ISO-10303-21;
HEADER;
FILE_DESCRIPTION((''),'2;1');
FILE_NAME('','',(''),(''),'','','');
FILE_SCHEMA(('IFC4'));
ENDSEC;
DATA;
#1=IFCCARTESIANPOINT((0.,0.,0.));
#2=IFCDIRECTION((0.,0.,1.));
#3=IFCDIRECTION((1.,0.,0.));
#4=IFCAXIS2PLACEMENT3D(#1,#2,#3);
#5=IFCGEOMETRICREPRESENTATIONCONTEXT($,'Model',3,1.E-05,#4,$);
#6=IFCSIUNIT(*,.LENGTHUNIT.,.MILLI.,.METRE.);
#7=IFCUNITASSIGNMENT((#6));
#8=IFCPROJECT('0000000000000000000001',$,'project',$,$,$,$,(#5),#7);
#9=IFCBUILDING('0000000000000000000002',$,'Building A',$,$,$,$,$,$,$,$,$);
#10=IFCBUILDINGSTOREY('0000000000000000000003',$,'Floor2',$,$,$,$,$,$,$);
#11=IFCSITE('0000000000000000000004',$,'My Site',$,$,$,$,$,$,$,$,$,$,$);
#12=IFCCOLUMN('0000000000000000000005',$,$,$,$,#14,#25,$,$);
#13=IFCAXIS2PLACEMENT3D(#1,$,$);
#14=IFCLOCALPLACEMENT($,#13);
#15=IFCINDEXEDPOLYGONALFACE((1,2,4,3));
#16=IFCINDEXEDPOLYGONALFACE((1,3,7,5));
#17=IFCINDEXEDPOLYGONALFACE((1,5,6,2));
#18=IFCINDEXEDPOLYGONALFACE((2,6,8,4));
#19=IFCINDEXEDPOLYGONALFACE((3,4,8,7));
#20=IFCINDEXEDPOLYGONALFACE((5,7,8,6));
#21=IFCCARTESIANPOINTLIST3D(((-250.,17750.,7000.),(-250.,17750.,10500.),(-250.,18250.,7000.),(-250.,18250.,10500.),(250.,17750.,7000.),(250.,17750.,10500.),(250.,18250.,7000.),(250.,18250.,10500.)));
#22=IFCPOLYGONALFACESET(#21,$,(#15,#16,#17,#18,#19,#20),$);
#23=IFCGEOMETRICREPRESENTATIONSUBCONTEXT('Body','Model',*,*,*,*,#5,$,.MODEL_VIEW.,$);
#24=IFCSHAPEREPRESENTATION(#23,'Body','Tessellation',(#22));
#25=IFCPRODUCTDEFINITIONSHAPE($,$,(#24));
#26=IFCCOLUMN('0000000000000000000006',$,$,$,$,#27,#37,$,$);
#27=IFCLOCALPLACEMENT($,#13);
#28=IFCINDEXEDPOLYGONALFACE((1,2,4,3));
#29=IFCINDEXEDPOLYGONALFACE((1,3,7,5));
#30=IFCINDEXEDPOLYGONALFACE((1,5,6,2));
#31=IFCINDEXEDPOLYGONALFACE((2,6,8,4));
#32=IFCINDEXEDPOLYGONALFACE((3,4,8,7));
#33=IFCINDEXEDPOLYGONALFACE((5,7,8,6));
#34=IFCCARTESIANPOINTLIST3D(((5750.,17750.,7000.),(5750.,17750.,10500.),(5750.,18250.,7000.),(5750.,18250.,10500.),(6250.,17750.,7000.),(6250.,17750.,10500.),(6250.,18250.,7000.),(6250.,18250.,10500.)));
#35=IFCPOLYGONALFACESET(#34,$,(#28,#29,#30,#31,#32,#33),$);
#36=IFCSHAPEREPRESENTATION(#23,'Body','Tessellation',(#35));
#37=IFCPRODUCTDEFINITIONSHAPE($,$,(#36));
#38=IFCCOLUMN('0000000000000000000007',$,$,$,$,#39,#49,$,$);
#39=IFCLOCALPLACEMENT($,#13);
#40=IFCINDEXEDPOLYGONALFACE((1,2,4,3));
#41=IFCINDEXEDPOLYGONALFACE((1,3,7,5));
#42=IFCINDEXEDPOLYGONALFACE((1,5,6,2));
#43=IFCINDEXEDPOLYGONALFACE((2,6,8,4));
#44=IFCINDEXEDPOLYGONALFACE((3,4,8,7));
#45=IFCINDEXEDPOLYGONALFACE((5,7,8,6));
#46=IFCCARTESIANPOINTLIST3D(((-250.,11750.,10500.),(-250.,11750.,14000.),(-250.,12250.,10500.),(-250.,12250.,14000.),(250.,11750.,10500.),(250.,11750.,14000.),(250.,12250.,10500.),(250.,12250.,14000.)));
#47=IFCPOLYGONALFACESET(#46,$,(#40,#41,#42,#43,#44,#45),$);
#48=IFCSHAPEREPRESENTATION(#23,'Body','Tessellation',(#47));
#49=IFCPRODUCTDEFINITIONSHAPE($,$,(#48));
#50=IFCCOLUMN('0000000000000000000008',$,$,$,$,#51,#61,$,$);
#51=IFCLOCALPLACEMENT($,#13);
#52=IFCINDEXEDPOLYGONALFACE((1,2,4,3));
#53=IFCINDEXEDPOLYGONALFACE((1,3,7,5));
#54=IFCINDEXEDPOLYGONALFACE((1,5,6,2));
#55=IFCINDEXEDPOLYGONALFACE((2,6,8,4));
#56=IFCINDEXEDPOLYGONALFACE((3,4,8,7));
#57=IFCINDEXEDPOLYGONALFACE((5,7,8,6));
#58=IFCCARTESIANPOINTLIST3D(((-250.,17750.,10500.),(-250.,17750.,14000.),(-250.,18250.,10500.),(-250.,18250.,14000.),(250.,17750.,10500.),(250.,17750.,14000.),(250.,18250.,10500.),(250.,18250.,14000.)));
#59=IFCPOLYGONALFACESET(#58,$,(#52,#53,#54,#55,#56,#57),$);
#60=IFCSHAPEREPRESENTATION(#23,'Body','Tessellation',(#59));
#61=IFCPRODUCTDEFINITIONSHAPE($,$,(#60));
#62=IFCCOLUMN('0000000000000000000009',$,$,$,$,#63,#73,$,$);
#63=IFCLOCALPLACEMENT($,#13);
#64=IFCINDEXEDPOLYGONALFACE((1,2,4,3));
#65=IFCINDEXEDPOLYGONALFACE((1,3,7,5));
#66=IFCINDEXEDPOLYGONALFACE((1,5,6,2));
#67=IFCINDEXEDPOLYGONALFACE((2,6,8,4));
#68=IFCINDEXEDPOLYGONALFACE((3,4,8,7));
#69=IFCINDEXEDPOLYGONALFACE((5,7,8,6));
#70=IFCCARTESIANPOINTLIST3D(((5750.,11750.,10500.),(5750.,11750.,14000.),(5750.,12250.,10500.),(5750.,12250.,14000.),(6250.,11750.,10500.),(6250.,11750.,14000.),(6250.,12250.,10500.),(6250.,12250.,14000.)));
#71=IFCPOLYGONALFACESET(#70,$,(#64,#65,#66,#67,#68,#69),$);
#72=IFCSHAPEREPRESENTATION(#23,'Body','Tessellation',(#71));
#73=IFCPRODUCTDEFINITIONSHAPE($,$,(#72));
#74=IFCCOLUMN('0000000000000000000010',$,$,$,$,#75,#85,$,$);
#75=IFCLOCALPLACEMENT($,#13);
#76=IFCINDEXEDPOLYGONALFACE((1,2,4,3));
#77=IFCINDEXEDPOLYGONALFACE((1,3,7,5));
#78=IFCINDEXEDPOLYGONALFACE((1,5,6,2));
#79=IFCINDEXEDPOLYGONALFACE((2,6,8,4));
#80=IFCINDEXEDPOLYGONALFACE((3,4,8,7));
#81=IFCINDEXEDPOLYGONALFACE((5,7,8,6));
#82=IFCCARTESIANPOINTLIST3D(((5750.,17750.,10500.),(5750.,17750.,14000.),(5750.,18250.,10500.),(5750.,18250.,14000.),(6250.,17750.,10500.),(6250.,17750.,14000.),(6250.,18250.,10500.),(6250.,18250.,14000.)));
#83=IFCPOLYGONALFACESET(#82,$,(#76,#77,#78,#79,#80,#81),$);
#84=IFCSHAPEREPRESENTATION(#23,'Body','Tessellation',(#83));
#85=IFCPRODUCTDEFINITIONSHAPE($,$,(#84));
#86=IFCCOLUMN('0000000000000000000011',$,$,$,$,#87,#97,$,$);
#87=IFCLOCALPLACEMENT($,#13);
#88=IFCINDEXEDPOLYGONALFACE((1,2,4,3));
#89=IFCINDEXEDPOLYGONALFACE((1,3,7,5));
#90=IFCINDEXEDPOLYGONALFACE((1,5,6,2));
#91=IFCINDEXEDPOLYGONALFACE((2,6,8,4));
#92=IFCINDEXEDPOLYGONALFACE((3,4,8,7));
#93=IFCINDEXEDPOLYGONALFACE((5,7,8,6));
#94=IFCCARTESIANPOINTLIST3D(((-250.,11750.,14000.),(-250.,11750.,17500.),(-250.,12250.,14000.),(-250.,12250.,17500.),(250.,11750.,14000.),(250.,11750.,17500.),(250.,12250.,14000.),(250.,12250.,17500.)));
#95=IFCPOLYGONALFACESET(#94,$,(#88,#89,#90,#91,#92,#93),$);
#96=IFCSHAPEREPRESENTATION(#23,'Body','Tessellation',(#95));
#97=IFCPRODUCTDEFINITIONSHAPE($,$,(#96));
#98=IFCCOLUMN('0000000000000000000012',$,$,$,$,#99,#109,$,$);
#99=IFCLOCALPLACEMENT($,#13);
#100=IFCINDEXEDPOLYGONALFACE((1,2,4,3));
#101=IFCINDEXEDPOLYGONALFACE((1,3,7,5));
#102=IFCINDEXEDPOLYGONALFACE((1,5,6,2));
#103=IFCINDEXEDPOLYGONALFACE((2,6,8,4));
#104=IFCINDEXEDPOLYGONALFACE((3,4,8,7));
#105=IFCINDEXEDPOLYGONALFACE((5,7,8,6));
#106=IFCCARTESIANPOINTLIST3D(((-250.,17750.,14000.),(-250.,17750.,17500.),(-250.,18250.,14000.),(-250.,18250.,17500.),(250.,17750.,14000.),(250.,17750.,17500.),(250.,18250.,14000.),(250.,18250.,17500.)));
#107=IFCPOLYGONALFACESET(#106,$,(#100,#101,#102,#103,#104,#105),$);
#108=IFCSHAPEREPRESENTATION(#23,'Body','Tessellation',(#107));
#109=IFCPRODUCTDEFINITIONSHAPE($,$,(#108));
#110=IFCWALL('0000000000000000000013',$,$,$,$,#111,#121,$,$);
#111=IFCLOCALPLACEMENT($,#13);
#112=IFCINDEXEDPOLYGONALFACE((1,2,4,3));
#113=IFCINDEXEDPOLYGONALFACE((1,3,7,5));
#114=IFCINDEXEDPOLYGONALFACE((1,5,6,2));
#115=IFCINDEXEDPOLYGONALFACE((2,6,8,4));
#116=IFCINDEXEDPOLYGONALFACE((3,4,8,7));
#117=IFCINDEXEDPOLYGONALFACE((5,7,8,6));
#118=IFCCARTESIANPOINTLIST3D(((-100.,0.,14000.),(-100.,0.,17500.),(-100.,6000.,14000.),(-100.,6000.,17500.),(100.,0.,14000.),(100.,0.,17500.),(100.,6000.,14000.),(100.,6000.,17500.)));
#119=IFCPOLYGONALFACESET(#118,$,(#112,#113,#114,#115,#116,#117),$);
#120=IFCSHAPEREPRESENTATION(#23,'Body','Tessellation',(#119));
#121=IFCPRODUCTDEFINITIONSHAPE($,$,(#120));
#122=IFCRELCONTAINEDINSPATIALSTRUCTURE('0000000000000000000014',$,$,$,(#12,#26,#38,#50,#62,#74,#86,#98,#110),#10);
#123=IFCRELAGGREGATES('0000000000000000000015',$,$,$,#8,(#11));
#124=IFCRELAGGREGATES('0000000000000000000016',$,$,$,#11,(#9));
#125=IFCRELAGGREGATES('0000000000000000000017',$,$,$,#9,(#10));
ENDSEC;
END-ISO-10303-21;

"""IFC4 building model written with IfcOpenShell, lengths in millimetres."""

from ifc_helpers import new_model, si_unit, frame, origin_with_axes, place, context, subcontext, project, spatial, line, indexed_curve, outline, extrude, element, save


model = new_model("IFC4")

# Units and contexts
model_context = context("Model", 3, precision=1e-05, world=origin_with_axes())
body_context = subcontext(model_context, "Body", "Model", "MODEL_VIEW")
ifc_project = project(units=[si_unit("LENGTHUNIT", "METRE", prefix="MILLI")], contexts=[model_context])

# Site, building, storey
site = spatial("IfcSite", under=ifc_project, Name="My Site")
building = spatial("IfcBuilding", under=site, Name="Building A")
storey = spatial("IfcBuildingStorey", under=building, Name="Floor2")

# Columns
for number, where, z_axis, x_axis in (
    (1, (0.0, 18000.0, 7000.0), (0.0, 0.0, 1.0), (1.0, 0.0, 0.0)),
    (2, (6000.0, 18000.0, 7000.0), (0.0, 0.0, 1.0), (1.0, 0.0, 0.0)),
    (3, (0.0, 12000.0, 10500.0), (0.0, 0.0, 1.0), (1.0, 0.0, 0.0)),
    (4, (0.0, 18000.0, 10500.0), (0.0, 0.0, 1.0), (1.0, 0.0, 0.0)),
    (5, (6000.0, 12000.0, 10500.0), (0.0, 0.0, 1.0), (1.0, 0.0, 0.0)),
    (6, (6000.0, 18000.0, 10500.0), (0.0, 0.0, 1.0), (1.0, 0.0, 0.0)),
    (7, (0.0, 12000.0, 14000.0), (0.0, 0.0, 1.0), (1.0, 0.0, 0.0)),
    (8, (0.0, 18000.0, 14000.0), (0.0, 0.0, 1.0), (1.0, 0.0, 0.0)),
):
    element("IfcColumn", number, at=place(None, frame(where, z_axis=z_axis, x_axis=x_axis)), inside=storey, context=body_context, shape_type="SweptSolid", body=[
        extrude(outline(indexed_curve([(-250.0, -250.0), (250.0, -250.0), (250.0, 250.0), (-250.0, 250.0)], segments=[line(1, 2, 3, 4, 1)])), origin_with_axes(), (0.0, 0.0, 1.0), 3500.0),
    ])

# Wall
wall_placement = place(None, frame((-100.0, 6000.0, 14000.0), z_axis=(0.0, 0.0, 1.0), x_axis=(0.0, -1.0, 0.0)))
element("IfcWall", 9, at=wall_placement, inside=storey, context=body_context, shape_type="SweptSolid", body=[
    extrude(outline(indexed_curve([(0.0, 0.0), (0.0, 200.0), (6000.0, 200.0), (6000.0, 0.0), (0.0, 0.0)], self_intersect=False)), origin_with_axes(), (0.0, 0.0, 1.0), 3500.0),
])

save(model, "model.ifc")
